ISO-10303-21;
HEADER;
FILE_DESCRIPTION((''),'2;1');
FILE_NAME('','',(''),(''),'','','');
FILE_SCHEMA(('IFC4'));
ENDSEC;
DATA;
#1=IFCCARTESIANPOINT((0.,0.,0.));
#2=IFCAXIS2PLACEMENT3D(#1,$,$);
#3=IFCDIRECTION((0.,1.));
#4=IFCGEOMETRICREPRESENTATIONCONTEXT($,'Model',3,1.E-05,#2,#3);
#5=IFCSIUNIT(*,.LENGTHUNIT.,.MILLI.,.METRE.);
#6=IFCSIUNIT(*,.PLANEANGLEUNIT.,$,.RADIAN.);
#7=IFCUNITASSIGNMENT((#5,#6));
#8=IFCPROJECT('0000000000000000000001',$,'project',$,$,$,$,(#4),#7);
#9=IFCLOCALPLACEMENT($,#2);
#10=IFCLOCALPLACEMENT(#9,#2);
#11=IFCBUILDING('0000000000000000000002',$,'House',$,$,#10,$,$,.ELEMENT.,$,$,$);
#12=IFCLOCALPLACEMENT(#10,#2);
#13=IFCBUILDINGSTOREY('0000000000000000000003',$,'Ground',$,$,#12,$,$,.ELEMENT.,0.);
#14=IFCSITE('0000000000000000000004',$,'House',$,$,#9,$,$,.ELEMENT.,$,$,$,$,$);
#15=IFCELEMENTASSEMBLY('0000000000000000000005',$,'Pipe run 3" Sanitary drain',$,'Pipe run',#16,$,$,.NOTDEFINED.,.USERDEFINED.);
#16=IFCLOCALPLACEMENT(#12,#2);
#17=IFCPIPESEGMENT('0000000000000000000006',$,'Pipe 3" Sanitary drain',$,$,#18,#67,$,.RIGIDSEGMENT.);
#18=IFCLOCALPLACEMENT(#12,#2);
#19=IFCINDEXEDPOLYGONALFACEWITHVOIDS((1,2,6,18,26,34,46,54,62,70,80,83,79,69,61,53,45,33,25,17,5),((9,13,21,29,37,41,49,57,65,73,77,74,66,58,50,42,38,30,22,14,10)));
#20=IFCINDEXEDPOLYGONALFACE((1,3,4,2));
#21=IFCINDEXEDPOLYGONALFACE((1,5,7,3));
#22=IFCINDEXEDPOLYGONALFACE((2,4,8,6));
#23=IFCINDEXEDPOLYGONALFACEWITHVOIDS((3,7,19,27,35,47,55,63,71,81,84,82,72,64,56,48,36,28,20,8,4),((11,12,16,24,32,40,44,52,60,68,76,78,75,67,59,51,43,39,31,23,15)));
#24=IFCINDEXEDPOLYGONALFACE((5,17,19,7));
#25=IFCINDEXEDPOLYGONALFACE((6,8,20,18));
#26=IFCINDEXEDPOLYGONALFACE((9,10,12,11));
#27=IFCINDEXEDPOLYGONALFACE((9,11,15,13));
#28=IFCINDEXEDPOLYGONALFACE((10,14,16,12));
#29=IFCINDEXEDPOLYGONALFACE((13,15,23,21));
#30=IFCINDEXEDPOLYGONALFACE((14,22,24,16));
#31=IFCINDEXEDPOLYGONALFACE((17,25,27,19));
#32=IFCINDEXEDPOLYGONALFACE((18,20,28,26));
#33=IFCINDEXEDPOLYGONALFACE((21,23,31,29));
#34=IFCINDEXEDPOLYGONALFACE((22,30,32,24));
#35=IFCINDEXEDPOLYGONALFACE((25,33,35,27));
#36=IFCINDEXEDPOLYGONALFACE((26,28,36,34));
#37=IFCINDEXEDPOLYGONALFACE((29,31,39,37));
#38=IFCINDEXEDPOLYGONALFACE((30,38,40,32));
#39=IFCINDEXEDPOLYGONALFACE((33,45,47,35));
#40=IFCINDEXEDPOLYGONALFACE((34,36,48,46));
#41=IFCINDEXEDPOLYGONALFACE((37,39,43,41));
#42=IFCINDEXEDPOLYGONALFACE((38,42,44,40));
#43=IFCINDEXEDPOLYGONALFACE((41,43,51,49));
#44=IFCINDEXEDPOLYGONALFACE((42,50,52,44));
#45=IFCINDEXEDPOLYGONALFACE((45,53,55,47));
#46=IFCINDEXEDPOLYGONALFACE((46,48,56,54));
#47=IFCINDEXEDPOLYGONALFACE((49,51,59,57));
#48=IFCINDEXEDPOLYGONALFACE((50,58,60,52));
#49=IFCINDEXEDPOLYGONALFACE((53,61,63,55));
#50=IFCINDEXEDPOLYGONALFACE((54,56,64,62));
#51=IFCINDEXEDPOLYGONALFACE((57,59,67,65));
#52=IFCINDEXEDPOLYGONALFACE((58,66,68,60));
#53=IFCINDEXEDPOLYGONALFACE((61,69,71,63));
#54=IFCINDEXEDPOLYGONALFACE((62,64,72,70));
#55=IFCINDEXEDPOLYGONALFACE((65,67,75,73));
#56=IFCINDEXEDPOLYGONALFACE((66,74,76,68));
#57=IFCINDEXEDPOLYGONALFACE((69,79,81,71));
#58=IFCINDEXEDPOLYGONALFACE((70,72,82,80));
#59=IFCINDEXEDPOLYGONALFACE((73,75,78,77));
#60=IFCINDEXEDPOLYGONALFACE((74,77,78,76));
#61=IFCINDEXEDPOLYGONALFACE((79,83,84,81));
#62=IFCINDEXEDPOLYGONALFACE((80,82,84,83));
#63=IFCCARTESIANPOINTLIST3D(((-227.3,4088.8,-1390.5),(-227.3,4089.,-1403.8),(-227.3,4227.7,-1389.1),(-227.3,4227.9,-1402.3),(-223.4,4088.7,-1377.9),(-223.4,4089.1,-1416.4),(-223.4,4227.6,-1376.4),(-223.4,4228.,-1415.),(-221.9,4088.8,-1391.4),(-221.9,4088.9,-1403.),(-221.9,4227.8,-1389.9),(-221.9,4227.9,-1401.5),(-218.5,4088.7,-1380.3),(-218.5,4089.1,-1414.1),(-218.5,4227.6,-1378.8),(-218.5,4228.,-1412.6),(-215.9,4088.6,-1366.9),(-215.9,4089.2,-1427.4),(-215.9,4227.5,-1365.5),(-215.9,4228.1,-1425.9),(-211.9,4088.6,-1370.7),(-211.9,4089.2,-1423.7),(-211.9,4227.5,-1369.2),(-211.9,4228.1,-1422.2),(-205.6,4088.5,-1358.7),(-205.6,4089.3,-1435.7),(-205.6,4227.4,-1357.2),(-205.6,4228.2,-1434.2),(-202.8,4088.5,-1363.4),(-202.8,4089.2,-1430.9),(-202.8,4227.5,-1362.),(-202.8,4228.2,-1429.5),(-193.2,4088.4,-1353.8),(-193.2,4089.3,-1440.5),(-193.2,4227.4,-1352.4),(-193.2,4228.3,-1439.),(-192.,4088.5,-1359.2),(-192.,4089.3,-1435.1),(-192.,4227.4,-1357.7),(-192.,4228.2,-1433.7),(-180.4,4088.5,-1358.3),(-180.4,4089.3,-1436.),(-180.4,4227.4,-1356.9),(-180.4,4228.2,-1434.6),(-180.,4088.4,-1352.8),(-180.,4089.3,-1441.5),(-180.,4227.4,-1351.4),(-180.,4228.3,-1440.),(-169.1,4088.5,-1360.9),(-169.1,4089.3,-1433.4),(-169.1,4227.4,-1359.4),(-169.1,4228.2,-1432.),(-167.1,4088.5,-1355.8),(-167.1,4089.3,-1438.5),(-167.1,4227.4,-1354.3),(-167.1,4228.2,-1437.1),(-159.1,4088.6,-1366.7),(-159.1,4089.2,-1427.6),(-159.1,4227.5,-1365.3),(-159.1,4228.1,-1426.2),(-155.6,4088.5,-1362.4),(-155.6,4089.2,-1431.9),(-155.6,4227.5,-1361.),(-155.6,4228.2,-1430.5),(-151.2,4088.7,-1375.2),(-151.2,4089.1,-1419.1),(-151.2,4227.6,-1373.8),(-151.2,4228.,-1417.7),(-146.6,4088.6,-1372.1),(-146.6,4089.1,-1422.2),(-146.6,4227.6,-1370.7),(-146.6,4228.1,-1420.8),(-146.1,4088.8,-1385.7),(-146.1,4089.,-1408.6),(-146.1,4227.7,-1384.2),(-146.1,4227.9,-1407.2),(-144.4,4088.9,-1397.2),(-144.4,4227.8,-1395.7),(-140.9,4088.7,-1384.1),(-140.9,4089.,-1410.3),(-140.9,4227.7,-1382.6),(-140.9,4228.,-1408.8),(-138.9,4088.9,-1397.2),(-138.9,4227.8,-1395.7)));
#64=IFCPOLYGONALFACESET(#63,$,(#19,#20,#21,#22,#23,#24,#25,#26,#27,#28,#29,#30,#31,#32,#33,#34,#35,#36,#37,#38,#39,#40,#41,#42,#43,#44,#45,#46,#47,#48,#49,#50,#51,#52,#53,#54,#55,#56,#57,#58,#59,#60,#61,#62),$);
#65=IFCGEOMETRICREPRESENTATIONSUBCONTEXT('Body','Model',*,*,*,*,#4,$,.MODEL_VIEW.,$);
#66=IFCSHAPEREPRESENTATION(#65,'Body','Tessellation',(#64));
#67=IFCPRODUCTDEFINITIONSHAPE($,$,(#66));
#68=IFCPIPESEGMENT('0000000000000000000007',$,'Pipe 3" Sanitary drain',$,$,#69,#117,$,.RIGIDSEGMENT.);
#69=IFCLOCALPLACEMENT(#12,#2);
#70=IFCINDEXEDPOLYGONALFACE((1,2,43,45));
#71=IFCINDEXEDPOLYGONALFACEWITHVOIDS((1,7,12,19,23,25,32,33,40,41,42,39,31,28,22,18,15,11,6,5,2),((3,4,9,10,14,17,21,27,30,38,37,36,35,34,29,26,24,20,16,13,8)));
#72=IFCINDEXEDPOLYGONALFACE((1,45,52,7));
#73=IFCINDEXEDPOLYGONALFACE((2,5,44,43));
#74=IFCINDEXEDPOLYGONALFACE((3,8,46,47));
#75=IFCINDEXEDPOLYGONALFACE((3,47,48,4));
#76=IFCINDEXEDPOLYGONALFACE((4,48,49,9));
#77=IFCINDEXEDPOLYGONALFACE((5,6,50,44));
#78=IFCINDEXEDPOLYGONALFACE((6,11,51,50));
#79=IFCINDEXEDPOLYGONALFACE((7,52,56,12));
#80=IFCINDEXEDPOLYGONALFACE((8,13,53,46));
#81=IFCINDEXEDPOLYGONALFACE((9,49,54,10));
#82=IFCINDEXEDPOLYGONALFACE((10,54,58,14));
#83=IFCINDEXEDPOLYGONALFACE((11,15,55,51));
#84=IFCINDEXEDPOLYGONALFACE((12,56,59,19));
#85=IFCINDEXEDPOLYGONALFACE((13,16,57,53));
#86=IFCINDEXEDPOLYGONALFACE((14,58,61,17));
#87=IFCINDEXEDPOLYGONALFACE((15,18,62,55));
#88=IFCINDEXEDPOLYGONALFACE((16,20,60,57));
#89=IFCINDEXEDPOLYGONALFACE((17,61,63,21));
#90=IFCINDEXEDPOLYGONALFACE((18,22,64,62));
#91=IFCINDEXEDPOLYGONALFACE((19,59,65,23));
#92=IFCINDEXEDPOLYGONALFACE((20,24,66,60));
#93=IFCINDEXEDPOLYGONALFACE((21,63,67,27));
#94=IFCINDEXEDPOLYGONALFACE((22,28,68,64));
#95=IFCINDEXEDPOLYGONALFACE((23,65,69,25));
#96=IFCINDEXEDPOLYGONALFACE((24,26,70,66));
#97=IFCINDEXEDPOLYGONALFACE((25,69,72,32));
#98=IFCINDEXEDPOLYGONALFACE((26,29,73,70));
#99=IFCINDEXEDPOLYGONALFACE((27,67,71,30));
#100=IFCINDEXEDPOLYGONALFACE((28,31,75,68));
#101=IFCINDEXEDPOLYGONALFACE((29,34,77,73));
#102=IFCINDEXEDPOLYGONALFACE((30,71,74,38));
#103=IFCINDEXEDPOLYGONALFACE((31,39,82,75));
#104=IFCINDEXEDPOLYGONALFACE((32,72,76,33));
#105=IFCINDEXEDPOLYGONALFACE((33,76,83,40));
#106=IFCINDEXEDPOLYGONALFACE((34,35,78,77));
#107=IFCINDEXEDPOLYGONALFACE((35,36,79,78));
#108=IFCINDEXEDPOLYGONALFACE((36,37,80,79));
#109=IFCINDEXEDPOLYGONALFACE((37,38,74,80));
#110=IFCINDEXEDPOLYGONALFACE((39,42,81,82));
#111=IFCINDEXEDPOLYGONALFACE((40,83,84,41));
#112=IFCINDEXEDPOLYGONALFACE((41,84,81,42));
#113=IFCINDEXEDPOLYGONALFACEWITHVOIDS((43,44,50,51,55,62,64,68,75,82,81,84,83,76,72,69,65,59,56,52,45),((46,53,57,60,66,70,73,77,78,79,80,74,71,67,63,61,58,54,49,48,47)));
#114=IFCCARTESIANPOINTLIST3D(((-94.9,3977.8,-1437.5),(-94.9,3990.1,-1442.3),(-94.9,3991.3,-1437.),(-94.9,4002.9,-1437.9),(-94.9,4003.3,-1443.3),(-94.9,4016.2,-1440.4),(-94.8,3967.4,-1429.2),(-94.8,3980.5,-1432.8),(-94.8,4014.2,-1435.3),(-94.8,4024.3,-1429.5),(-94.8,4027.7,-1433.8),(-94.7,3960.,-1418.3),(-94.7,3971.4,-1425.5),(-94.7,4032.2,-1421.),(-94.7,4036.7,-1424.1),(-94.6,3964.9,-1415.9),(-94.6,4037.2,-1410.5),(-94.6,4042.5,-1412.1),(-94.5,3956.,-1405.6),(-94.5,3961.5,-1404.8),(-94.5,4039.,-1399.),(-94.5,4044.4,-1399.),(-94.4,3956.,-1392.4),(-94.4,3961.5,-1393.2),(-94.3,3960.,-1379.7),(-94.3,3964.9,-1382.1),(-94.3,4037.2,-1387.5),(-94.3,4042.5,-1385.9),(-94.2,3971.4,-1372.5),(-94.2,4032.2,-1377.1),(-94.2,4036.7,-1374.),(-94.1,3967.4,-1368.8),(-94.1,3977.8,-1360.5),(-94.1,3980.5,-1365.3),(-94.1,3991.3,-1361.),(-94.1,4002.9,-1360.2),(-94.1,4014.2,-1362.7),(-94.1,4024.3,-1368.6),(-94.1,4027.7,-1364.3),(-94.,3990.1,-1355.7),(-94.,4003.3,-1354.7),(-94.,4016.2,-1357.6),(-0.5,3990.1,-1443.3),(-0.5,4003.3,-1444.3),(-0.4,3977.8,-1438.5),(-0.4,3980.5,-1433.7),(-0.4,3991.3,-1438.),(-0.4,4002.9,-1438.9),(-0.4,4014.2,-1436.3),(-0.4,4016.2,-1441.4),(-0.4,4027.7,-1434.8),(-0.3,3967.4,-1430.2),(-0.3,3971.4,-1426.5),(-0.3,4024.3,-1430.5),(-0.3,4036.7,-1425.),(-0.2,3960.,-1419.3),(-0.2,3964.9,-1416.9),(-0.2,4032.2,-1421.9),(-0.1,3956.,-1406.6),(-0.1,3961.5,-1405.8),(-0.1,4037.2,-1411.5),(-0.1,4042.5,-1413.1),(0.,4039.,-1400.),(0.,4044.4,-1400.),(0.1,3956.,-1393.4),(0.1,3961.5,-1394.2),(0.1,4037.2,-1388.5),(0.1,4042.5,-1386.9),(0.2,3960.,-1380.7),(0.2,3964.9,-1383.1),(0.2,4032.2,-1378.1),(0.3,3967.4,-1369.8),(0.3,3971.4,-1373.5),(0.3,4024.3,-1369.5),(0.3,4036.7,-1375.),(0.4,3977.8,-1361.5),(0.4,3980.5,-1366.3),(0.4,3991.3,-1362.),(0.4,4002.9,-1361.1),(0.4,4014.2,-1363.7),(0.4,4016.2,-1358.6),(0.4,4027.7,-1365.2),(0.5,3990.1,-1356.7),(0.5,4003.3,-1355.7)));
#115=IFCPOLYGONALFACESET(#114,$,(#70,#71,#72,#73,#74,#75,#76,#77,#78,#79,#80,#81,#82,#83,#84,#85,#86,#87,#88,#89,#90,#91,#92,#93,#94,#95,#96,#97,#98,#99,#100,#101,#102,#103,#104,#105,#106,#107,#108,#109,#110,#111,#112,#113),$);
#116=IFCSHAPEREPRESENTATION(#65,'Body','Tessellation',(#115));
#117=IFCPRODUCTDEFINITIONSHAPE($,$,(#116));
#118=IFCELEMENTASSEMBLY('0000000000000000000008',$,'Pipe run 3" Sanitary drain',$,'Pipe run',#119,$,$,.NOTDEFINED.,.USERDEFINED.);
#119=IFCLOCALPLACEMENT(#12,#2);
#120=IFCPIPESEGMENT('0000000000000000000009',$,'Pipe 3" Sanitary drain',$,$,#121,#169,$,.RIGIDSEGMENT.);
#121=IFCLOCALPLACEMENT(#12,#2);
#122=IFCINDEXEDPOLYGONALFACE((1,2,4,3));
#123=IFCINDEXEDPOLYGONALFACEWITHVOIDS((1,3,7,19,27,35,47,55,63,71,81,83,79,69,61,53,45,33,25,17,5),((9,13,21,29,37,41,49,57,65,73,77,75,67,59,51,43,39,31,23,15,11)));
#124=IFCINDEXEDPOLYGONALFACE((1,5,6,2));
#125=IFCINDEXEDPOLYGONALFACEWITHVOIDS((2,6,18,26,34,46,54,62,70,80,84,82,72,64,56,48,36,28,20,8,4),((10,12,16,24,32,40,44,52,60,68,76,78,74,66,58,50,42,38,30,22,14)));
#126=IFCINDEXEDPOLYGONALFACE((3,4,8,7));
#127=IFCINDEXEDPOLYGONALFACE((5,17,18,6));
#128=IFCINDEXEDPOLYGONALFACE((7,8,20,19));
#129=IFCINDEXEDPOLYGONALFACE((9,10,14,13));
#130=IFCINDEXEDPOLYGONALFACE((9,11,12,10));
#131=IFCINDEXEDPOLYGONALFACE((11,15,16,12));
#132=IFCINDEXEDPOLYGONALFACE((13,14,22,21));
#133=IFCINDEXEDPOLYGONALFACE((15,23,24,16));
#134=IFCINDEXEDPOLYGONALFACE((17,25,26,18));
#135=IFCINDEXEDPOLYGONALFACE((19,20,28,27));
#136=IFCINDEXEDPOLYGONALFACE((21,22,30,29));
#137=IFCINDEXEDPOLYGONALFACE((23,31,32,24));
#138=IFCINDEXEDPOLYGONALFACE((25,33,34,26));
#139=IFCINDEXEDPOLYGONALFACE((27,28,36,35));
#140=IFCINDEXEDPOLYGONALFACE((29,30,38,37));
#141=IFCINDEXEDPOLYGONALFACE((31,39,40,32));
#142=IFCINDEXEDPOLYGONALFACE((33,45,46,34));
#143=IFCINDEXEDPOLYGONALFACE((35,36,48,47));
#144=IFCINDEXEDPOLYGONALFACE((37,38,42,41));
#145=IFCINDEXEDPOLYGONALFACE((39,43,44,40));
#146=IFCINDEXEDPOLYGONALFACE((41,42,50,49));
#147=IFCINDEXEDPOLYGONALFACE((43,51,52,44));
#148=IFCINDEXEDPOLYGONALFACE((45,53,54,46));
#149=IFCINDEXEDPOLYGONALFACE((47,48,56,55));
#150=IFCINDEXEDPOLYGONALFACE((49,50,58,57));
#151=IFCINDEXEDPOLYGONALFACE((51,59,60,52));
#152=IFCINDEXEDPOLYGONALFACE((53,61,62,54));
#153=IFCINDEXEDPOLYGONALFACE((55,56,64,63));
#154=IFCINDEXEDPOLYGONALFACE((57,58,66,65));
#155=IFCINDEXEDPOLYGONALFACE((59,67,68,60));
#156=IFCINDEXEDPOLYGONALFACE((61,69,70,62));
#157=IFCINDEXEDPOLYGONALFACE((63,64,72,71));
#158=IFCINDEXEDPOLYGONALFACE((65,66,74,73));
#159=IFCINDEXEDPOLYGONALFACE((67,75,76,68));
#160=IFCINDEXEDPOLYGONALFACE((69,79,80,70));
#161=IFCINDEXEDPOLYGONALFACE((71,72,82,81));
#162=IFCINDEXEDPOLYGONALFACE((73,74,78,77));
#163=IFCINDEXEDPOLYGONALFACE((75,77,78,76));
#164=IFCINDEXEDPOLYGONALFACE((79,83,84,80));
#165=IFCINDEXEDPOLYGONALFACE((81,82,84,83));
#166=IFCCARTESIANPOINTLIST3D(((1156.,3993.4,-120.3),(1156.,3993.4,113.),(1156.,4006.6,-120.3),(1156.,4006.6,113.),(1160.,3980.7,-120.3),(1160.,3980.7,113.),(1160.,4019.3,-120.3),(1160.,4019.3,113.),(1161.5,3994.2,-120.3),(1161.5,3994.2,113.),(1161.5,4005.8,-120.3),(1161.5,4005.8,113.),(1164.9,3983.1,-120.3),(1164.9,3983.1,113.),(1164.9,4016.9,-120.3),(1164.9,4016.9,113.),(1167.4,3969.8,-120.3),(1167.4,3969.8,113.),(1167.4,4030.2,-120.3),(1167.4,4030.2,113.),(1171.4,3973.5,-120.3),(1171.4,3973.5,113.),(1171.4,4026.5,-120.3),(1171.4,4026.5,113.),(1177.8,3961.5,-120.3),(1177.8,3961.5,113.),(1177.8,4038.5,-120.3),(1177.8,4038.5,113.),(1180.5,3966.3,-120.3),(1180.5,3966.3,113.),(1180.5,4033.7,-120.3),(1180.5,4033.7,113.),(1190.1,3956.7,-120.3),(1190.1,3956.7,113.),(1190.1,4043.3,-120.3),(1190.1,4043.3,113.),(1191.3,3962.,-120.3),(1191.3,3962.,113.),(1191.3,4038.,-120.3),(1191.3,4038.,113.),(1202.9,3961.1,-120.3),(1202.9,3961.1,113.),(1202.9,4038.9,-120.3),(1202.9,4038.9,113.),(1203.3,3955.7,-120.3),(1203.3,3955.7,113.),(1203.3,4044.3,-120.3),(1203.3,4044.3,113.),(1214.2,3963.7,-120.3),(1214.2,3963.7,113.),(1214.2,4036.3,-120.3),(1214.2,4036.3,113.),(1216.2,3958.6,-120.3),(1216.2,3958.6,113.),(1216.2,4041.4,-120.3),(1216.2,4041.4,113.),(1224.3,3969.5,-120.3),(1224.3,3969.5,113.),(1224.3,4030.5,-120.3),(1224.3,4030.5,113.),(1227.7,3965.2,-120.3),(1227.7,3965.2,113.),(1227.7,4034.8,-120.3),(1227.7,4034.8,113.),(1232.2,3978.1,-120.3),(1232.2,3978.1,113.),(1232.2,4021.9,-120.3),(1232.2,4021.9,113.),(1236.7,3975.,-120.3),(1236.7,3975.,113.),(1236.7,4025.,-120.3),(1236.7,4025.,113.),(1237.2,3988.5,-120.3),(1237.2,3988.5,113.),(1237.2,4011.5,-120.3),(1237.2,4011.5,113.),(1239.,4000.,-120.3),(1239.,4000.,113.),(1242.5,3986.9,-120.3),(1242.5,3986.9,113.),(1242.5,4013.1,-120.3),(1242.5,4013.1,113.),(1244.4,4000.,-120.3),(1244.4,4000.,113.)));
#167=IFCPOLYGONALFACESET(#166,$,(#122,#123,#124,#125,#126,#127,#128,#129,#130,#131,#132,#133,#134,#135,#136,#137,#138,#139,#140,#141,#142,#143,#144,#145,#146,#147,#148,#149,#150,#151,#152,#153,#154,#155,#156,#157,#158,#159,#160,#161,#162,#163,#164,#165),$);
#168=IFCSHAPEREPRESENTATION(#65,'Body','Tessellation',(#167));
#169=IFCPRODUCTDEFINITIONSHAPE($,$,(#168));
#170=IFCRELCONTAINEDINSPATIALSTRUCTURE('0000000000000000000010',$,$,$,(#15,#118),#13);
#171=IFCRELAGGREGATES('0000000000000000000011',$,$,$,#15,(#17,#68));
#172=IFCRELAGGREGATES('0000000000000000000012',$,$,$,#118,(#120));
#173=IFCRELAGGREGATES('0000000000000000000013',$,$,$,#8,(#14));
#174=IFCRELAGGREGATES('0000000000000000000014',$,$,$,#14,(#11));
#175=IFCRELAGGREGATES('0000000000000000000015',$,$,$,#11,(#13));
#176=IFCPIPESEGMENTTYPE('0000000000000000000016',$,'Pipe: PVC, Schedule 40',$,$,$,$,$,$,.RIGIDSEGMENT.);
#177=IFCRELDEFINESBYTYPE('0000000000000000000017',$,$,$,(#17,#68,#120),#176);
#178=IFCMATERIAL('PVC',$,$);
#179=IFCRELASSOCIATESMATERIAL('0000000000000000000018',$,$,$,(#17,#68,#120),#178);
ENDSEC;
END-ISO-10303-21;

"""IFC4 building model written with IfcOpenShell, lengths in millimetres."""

from ifc_helpers import new_model, si_unit, direction, frame, origin, origin_with_axes, origin_2d, place, context, subcontext, project, spatial, hollow_circle, extrude, material, type_object, element, aggregate, save


model = new_model("IFC4")

# Units and contexts
model_context = context("Model", 3, precision=1e-05, world=origin(), true_north=direction((0.0, 1.0)))
body_context = subcontext(model_context, "Body", "Model", "MODEL_VIEW")
ifc_project = project(units=[si_unit("LENGTHUNIT", "METRE", prefix="MILLI"), si_unit("PLANEANGLEUNIT", "RADIAN")], contexts=[model_context])

# Site, building, storey
site_placement = place(None, origin())
site = spatial("IfcSite", under=ifc_project, at=site_placement, Name="House", CompositionType="ELEMENT")
building_placement = place(site_placement, origin())
building = spatial("IfcBuilding", under=site, at=building_placement, Name="House", CompositionType="ELEMENT")
storey_placement = place(building_placement, origin())
storey = spatial("IfcBuildingStorey", under=building, at=storey_placement, Name="Ground", CompositionType="ELEMENT", Elevation=0.0)

# Element assemblies, pipe segments
assembly_1_placement = place(storey_placement, origin_with_axes())
assembly_1 = element("IfcElementAssembly", 1, at=assembly_1_placement, inside=storey, Name="Pipe run 3\" Sanitary drain", ObjectType="Pipe run", AssemblyPlace="NOTDEFINED", PredefinedType="USERDEFINED")
ifc_material = material(Name="PVC")
pipe_segment_type = type_object("IfcPipeSegmentType", Name="Pipe: PVC, Schedule 40", PredefinedType="RIGIDSEGMENT")
pipe_segment_1_placement = place(storey_placement, origin_with_axes())
pipe_segment_1 = element("IfcPipeSegment", 2, at=pipe_segment_1_placement, type_object=pipe_segment_type, material=ifc_material, Name="Pipe 3\" Sanitary drain", PredefinedType="RIGIDSEGMENT", context=body_context, shape_type="SweptSolid", body=[
    extrude(hollow_circle(Radius=44.5, WallThickness=5.5, at=origin_2d()), frame((-183.3, 4227.8, -1395.7), z_axis=(0.0, -0.999946, -0.010416), x_axis=(1.0, 0.0, 0.0)), (0.0, 0.0, 1.0), 138.9),
])
pipe_segment_2_placement = place(storey_placement, origin_with_axes())
pipe_segment_2 = element("IfcPipeSegment", 3, at=pipe_segment_2_placement, type_object=pipe_segment_type, material=ifc_material, Name="Pipe 3\" Sanitary drain", PredefinedType="RIGIDSEGMENT", context=body_context, shape_type="SweptSolid", body=[
    extrude(hollow_circle(Radius=44.5, WallThickness=5.5, at=origin_2d()), frame((-94.5, 4000.0, -1399.0), z_axis=(0.999946, 0.0, -0.010416), x_axis=(0.0, 1.0, 0.0)), (0.0, 0.0, 1.0), 94.5),
])
assembly_2_placement = place(storey_placement, origin_with_axes())
assembly_2 = element("IfcElementAssembly", 4, at=assembly_2_placement, inside=storey, Name="Pipe run 3\" Sanitary drain", ObjectType="Pipe run", AssemblyPlace="NOTDEFINED", PredefinedType="USERDEFINED")
pipe_segment_3_placement = place(storey_placement, origin_with_axes())
pipe_segment_3 = element("IfcPipeSegment", 5, at=pipe_segment_3_placement, type_object=pipe_segment_type, material=ifc_material, Name="Pipe 3\" Sanitary drain", PredefinedType="RIGIDSEGMENT", context=body_context, shape_type="SweptSolid", body=[
    extrude(hollow_circle(Radius=44.5, WallThickness=5.5, at=origin_2d()), frame((1200.0, 4000.0, 113.0), z_axis=(0.0, 0.0, -1.0), x_axis=(1.0, 0.0, 0.0)), (0.0, 0.0, 1.0), 233.3),
])

aggregate(assembly_1, [pipe_segment_1, pipe_segment_2])
aggregate(assembly_2, [pipe_segment_3])

save(model, "model.ifc")
